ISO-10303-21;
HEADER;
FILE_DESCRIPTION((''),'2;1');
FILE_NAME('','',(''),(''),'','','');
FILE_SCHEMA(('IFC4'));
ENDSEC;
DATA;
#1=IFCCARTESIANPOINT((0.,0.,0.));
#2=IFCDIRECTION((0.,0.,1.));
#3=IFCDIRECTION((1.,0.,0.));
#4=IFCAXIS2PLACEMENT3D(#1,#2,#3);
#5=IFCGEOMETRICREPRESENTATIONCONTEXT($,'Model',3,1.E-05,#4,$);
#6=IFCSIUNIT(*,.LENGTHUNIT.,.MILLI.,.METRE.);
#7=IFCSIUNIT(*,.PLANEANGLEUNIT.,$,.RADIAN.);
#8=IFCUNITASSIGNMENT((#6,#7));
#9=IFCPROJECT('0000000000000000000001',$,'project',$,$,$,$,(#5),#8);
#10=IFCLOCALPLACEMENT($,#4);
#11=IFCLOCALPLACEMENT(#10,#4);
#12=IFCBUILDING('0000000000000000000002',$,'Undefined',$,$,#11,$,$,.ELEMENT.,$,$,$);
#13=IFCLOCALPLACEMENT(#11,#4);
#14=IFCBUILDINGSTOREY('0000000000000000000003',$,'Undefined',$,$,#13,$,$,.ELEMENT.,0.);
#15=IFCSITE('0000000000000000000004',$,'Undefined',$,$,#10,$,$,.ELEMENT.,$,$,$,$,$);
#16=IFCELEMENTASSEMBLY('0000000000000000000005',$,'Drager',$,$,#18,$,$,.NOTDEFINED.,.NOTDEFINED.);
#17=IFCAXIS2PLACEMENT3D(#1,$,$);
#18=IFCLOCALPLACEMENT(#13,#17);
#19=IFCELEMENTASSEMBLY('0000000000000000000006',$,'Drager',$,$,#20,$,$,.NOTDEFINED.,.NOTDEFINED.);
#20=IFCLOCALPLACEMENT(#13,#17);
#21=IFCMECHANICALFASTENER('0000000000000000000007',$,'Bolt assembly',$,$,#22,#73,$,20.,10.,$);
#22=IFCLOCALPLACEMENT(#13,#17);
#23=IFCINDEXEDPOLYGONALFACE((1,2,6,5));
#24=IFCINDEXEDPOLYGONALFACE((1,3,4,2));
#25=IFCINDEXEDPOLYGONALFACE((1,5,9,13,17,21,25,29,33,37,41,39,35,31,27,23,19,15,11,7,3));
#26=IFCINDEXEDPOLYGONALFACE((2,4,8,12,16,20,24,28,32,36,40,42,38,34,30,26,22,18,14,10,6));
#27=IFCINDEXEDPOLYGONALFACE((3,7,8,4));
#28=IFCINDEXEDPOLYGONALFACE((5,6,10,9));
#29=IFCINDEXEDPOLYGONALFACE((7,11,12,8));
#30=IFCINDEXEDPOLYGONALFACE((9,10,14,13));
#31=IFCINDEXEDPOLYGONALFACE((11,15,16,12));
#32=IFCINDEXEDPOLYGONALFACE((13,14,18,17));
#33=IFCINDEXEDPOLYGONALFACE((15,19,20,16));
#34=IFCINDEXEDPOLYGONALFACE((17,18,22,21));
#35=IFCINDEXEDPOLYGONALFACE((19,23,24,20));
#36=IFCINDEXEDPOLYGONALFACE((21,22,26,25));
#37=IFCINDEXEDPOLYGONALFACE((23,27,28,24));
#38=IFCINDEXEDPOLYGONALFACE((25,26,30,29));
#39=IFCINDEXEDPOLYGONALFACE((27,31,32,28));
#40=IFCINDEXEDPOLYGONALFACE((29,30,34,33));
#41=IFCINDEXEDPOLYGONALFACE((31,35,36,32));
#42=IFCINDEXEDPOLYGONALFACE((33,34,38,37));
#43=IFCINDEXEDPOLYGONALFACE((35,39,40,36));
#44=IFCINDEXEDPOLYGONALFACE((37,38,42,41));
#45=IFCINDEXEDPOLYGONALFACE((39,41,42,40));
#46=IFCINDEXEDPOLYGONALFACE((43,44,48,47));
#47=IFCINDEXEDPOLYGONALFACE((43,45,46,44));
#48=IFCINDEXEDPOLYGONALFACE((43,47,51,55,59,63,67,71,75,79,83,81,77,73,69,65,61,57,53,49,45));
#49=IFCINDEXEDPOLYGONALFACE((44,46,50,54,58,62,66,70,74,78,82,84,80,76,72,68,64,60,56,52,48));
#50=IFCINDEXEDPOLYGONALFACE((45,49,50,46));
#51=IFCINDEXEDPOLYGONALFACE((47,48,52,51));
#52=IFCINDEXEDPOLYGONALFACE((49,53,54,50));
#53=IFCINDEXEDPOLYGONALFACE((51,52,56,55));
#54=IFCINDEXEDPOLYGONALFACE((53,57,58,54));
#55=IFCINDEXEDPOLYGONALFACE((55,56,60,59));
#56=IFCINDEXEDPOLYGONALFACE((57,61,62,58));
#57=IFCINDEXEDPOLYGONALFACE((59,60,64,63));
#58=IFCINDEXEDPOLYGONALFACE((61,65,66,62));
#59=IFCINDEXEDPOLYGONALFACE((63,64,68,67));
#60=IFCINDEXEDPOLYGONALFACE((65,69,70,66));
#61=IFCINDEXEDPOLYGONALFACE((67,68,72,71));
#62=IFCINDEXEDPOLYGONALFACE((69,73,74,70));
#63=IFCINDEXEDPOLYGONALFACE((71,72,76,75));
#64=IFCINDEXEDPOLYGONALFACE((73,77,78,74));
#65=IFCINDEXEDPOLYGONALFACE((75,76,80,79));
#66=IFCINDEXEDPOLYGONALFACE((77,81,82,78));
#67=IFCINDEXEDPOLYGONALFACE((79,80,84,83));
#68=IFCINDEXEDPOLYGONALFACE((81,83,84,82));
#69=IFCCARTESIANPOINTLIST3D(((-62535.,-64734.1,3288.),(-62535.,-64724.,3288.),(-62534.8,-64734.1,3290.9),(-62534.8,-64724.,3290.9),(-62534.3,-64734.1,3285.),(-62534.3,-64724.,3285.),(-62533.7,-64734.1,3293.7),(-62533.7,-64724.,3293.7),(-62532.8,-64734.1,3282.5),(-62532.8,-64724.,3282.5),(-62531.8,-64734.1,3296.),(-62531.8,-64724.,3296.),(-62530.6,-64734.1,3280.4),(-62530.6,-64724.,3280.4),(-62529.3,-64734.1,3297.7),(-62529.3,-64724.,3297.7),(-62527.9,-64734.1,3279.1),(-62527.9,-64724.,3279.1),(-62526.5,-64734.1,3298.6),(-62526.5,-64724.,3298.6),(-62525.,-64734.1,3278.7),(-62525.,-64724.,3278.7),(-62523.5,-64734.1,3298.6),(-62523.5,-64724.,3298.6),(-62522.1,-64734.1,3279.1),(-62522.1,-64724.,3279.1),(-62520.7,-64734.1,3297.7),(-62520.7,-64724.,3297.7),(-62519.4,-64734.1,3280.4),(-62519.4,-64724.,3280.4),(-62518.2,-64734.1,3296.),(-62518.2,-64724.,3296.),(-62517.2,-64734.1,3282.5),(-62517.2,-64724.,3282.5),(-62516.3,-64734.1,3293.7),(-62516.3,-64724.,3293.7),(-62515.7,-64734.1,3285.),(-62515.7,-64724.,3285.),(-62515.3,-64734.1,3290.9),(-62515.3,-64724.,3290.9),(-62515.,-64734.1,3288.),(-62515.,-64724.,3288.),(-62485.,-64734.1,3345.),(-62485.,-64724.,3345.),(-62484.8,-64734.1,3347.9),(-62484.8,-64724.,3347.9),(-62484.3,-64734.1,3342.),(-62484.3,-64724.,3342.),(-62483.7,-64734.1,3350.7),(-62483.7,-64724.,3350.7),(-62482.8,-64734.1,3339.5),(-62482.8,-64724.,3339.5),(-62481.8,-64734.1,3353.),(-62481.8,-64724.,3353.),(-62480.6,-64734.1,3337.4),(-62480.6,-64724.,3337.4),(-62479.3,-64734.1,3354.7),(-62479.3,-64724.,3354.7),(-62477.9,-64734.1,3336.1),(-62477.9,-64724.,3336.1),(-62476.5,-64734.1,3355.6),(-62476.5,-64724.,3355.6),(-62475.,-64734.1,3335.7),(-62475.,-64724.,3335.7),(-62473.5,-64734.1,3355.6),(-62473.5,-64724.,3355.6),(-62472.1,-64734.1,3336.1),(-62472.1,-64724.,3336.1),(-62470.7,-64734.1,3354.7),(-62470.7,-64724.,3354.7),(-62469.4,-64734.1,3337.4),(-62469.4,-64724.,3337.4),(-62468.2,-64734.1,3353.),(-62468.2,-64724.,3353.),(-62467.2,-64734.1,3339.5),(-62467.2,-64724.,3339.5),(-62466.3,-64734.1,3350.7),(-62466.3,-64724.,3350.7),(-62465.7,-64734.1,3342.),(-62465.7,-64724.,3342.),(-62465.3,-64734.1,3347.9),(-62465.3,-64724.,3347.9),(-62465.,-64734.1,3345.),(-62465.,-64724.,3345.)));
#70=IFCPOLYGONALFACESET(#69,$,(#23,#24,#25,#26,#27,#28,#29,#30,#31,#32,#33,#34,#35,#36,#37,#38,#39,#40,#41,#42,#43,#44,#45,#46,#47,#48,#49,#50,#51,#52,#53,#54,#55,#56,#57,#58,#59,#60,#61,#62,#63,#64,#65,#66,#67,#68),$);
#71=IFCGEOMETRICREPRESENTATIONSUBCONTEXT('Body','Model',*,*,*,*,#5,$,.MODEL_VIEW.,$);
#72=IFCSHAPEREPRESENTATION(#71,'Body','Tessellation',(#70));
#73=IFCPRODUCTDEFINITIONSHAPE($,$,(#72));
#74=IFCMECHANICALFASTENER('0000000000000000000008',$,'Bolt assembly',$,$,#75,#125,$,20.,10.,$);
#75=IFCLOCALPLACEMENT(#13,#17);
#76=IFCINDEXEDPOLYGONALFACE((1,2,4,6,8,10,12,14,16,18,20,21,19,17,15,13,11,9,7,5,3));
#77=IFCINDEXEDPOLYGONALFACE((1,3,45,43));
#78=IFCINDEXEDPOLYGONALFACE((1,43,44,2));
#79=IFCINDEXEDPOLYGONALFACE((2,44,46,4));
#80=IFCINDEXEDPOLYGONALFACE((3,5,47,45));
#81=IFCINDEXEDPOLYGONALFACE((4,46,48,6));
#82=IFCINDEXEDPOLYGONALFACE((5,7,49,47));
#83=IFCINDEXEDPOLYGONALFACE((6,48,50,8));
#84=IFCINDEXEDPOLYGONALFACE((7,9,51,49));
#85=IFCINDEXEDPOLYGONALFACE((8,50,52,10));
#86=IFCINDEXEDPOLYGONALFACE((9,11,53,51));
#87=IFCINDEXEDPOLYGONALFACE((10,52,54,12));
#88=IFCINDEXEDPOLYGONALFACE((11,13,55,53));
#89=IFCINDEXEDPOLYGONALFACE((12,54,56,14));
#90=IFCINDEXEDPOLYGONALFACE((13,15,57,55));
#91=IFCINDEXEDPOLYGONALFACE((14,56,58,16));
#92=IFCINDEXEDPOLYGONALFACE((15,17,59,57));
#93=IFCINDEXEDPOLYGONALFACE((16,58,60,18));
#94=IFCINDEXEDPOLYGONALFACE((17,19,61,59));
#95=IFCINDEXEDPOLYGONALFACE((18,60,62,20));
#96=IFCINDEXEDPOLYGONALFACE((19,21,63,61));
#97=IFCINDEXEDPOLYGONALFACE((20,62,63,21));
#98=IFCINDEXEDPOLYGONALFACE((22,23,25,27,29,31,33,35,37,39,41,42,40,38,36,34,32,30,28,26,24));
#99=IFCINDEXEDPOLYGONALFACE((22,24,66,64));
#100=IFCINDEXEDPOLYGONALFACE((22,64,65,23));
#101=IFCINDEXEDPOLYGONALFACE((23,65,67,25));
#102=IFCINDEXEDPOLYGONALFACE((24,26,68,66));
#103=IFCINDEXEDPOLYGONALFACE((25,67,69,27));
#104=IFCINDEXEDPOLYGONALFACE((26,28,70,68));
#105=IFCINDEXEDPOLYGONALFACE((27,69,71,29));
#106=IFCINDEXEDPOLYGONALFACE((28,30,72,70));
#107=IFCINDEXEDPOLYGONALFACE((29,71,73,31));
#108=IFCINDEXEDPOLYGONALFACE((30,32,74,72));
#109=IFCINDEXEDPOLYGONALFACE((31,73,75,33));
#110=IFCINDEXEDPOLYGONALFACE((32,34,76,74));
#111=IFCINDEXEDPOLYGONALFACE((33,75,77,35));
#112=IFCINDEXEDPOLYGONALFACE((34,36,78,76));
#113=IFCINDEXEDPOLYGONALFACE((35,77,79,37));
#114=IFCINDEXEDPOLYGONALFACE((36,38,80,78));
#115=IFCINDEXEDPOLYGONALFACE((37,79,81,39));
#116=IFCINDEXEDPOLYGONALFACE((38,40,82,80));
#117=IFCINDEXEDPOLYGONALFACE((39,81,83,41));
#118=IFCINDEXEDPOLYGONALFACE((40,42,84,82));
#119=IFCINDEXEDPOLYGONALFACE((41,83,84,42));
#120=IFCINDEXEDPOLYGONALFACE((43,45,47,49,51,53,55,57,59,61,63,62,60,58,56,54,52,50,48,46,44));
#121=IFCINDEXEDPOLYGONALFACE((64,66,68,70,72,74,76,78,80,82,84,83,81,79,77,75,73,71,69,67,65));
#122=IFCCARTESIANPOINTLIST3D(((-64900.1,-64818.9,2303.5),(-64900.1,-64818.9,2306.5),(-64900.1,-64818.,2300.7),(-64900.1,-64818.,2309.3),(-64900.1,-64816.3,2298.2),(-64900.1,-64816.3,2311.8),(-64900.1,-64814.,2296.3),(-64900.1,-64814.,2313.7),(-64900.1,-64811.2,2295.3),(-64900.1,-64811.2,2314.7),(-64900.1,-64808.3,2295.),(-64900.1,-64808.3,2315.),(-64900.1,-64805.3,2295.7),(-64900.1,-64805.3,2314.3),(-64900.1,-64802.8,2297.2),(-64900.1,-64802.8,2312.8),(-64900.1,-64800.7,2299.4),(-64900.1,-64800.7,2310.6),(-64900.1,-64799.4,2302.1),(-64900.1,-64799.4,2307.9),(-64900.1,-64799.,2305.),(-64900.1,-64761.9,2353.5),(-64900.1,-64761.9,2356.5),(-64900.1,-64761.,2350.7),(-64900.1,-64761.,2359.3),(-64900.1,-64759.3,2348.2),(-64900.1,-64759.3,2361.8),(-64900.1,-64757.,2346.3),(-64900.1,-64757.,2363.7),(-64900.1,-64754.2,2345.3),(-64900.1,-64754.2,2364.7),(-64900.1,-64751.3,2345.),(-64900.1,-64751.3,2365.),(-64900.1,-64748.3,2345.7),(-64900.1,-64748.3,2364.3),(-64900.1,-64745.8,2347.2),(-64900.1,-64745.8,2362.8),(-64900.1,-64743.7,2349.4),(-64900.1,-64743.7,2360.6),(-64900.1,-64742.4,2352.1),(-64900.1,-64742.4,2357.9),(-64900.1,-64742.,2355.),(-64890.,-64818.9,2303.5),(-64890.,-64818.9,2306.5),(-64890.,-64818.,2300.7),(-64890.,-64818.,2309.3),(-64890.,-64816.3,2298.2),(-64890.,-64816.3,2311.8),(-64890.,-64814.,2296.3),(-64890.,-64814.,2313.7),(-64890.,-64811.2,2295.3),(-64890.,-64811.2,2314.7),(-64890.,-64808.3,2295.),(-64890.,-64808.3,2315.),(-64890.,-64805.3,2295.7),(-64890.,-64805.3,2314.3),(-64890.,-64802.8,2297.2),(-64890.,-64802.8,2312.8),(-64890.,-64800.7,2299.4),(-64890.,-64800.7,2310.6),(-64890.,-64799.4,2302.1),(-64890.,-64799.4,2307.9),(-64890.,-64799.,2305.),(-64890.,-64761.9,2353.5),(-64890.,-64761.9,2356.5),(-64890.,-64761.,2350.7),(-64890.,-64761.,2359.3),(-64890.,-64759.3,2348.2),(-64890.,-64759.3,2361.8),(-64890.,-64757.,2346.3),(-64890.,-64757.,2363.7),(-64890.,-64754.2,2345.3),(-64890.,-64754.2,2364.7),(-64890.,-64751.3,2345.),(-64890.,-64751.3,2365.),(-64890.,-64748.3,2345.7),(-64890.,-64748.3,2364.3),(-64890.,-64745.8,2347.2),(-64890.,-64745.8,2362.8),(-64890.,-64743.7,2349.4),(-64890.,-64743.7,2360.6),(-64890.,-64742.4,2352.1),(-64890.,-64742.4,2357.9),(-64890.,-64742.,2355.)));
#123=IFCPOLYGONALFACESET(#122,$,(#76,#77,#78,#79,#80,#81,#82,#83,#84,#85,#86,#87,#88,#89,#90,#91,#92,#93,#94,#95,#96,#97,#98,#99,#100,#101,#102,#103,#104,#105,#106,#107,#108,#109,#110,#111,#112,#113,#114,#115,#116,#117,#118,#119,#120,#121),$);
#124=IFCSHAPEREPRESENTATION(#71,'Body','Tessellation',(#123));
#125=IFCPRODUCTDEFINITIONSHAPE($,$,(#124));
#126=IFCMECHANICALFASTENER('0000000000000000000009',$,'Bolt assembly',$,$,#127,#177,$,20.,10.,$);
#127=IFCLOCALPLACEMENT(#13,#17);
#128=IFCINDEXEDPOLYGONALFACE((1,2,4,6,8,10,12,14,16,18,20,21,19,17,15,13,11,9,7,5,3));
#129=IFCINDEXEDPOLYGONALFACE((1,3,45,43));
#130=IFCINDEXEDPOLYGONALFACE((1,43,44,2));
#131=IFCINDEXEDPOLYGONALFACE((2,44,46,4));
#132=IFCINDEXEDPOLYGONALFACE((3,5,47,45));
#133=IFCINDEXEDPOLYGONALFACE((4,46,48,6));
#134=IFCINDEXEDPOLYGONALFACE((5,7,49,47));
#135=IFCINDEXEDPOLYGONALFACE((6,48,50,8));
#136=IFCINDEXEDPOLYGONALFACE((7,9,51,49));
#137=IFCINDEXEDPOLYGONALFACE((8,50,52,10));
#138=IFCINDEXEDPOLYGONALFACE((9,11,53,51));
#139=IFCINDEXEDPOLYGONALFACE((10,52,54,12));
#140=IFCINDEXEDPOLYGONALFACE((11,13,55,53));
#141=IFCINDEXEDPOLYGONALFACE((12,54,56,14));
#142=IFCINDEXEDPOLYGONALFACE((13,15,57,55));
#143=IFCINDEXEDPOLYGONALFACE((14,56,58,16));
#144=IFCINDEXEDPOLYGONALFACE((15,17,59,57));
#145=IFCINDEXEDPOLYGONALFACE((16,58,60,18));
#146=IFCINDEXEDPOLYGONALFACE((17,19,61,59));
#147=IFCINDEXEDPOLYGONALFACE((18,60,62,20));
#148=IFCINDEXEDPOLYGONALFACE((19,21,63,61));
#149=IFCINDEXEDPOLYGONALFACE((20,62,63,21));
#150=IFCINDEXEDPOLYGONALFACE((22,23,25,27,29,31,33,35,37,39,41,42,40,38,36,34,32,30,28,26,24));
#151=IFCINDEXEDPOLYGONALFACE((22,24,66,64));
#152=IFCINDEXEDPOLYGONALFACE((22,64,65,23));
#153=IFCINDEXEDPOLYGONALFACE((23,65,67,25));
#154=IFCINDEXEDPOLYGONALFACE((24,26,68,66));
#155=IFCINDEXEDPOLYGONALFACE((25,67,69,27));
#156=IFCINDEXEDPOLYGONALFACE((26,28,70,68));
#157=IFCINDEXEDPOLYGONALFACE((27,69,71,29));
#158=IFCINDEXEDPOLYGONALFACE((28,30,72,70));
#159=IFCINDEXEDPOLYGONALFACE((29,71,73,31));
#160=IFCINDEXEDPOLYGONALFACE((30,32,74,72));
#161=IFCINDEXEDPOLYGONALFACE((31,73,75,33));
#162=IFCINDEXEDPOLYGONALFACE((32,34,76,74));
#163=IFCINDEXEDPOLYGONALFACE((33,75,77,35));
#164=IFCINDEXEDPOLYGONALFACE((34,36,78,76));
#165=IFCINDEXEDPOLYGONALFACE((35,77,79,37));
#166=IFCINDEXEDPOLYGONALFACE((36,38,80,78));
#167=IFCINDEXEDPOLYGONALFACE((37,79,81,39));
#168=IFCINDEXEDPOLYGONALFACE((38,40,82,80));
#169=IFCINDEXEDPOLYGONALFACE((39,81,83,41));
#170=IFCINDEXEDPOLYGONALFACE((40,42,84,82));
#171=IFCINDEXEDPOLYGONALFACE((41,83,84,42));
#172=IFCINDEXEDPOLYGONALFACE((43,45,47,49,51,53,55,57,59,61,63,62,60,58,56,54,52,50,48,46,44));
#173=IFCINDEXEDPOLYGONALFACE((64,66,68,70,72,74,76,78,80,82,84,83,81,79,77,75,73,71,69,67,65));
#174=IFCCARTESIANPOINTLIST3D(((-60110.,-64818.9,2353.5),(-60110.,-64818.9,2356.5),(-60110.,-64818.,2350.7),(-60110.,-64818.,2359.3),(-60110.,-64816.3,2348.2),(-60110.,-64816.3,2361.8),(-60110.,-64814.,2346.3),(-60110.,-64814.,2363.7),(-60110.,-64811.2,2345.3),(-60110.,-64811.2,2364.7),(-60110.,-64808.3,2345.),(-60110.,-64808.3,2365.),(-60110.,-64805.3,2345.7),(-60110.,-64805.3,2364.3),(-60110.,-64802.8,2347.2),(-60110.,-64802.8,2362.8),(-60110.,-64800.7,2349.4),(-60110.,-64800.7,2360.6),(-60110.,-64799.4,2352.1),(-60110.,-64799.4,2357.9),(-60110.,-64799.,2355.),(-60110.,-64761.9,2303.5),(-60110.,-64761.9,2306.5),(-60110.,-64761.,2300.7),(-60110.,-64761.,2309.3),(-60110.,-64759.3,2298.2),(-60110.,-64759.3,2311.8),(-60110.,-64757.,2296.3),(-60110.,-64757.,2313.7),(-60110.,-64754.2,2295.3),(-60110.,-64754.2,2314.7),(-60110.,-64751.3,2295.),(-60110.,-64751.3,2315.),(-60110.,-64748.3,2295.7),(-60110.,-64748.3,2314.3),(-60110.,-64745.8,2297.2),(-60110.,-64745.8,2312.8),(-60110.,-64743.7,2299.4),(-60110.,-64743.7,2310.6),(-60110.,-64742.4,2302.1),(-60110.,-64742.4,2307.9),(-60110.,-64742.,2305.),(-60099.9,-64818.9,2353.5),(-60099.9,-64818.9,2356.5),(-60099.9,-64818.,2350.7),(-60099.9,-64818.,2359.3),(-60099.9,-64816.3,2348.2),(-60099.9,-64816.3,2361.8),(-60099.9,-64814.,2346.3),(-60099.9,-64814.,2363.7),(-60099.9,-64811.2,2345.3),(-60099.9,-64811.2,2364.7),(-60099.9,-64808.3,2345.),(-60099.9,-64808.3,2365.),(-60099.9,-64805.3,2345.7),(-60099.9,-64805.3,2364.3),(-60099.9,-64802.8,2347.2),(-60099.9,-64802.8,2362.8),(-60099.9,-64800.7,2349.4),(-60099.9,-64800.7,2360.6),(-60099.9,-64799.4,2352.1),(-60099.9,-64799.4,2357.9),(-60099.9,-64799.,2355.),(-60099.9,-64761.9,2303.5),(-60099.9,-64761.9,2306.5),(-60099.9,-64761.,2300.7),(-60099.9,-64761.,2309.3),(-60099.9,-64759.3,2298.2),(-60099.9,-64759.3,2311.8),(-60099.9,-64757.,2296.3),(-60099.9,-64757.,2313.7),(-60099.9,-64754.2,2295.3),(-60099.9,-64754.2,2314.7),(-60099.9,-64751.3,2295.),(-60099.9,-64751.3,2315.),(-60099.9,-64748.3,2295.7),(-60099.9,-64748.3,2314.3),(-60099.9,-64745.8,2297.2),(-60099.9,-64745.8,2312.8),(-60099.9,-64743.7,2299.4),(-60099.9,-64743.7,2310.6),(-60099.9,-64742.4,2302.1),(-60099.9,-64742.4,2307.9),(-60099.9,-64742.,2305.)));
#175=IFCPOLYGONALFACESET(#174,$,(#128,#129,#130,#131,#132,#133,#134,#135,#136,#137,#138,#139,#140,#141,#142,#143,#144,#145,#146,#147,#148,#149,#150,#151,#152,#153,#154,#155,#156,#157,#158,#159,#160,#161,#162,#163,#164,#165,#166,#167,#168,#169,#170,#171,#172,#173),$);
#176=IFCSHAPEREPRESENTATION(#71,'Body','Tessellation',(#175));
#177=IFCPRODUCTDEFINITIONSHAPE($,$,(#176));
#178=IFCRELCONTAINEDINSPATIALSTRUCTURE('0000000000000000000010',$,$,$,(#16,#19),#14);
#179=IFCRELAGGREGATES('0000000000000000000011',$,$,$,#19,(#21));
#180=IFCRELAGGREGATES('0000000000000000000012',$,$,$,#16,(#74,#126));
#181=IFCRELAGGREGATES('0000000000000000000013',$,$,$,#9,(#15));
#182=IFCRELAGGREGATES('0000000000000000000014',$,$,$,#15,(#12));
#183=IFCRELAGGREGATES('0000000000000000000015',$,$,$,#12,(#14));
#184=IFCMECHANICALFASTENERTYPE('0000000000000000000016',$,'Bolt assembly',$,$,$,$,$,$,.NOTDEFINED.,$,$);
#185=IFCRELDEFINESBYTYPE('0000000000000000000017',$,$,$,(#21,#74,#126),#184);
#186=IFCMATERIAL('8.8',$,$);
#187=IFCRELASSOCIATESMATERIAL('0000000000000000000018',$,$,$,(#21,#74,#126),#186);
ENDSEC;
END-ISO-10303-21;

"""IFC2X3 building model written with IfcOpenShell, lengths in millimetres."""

from ifc_helpers import new_model, si_unit, frame, origin_with_axes, origin_2d_with_axis, place, context, subcontext, project, spatial, circle, extrude, source, transform, mapped, material, type_object, element, aggregate, save


model = new_model("IFC2X3")

# Units and contexts
model_context = context("Model", 3, precision=1e-05, world=origin_with_axes())
body_context = subcontext(model_context, "Body", "Model", "MODEL_VIEW")
ifc_project = project(units=[si_unit("LENGTHUNIT", "METRE", prefix="MILLI"), si_unit("PLANEANGLEUNIT", "RADIAN")], contexts=[model_context])

# Site, building, storey
site_placement = place(None, origin_with_axes())
site = spatial("IfcSite", under=ifc_project, at=site_placement, Name="Undefined", CompositionType="ELEMENT")
building_placement = place(site_placement, origin_with_axes())
building = spatial("IfcBuilding", under=site, at=building_placement, Name="Undefined", CompositionType="ELEMENT")
storey_placement = place(building_placement, origin_with_axes())
storey = spatial("IfcBuildingStorey", under=building, at=storey_placement, Name="Undefined", CompositionType="ELEMENT", Elevation=0.0)

# Element assembly
assembly_1_placement = place(storey_placement, origin_with_axes())
assembly_1 = element("IfcElementAssembly", 1, at=assembly_1_placement, inside=storey, Name="Drager", AssemblyPlace="NOTDEFINED", PredefinedType="NOTDEFINED")

# Element assembly
assembly_2_placement = place(storey_placement, origin_with_axes())
assembly_2 = element("IfcElementAssembly", 2, at=assembly_2_placement, inside=storey, Name="Drager", AssemblyPlace="NOTDEFINED", PredefinedType="NOTDEFINED")

# Shared definitions
ifc_material_1 = material(Name="8.8")
mechanical_fastener_type = type_object("IfcMechanicalFastenerType", Name="Bolt assembly")
shared_shape_1 = source(origin_with_axes(), body_context, "Body", "SweptSolid", [
    extrude(circle(Radius=10.0, at=origin_2d_with_axis()), frame((0.0, 0.0, 0.0), z_axis=(0.0, 1.0, 0.0), x_axis=(1.0, 0.0, 0.0)), (0.0, 0.0, 1.0), 10.1),
])

# Mechanical fasteners
mechanical_fastener_1_placement = place(assembly_2_placement, frame((-62500.0, -64724.0, 3345.7), z_axis=(-1.0, 0.0, 0.0), x_axis=(0.0, 0.0, -1.0)))
mechanical_fastener_1 = element("IfcMechanicalFastener", 3, at=mechanical_fastener_1_placement, type_object=mechanical_fastener_type, material=ifc_material_1, Name="Bolt assembly", NominalDiameter=20.0, NominalLength=10.0, context=body_context, shape_type="MappedRepresentation", body=[
    mapped(shared_shape_1, transform((0.0, 0.0, -25.0))),
    mapped(shared_shape_1, transform((57.0, 0.0, 25.0))),
])
mechanical_fastener_2_placement = place(assembly_1_placement, frame((-64890.0, -64809.0, 2330.0), z_axis=(0.0, 0.0, 1.0), x_axis=(0.0, 1.0, 0.0)))
mechanical_fastener_2 = element("IfcMechanicalFastener", 4, at=mechanical_fastener_2_placement, type_object=mechanical_fastener_type, material=ifc_material_1, Name="Bolt assembly", NominalDiameter=20.0, NominalLength=10.0, context=body_context, shape_type="MappedRepresentation", body=[
    mapped(shared_shape_1, transform((0.0, 0.0, -25.0))),
    mapped(shared_shape_1, transform((57.0, 0.0, 25.0))),
])
mechanical_fastener_3_placement = place(assembly_1_placement, frame((-60110.0, -64809.0, 2330.0), z_axis=(0.0, 0.0, -1.0), x_axis=(0.0, 1.0, 0.0)))
mechanical_fastener_3 = element("IfcMechanicalFastener", 5, at=mechanical_fastener_3_placement, type_object=mechanical_fastener_type, material=ifc_material_1, Name="Bolt assembly", NominalDiameter=20.0, NominalLength=10.0, context=body_context, shape_type="MappedRepresentation", body=[
    mapped(shared_shape_1, transform((0.0, 0.0, -25.0))),
    mapped(shared_shape_1, transform((57.0, 0.0, 25.0))),
])
aggregate(assembly_2, [mechanical_fastener_1])
aggregate(assembly_1, [mechanical_fastener_2, mechanical_fastener_3])

save(model, "model.ifc")
